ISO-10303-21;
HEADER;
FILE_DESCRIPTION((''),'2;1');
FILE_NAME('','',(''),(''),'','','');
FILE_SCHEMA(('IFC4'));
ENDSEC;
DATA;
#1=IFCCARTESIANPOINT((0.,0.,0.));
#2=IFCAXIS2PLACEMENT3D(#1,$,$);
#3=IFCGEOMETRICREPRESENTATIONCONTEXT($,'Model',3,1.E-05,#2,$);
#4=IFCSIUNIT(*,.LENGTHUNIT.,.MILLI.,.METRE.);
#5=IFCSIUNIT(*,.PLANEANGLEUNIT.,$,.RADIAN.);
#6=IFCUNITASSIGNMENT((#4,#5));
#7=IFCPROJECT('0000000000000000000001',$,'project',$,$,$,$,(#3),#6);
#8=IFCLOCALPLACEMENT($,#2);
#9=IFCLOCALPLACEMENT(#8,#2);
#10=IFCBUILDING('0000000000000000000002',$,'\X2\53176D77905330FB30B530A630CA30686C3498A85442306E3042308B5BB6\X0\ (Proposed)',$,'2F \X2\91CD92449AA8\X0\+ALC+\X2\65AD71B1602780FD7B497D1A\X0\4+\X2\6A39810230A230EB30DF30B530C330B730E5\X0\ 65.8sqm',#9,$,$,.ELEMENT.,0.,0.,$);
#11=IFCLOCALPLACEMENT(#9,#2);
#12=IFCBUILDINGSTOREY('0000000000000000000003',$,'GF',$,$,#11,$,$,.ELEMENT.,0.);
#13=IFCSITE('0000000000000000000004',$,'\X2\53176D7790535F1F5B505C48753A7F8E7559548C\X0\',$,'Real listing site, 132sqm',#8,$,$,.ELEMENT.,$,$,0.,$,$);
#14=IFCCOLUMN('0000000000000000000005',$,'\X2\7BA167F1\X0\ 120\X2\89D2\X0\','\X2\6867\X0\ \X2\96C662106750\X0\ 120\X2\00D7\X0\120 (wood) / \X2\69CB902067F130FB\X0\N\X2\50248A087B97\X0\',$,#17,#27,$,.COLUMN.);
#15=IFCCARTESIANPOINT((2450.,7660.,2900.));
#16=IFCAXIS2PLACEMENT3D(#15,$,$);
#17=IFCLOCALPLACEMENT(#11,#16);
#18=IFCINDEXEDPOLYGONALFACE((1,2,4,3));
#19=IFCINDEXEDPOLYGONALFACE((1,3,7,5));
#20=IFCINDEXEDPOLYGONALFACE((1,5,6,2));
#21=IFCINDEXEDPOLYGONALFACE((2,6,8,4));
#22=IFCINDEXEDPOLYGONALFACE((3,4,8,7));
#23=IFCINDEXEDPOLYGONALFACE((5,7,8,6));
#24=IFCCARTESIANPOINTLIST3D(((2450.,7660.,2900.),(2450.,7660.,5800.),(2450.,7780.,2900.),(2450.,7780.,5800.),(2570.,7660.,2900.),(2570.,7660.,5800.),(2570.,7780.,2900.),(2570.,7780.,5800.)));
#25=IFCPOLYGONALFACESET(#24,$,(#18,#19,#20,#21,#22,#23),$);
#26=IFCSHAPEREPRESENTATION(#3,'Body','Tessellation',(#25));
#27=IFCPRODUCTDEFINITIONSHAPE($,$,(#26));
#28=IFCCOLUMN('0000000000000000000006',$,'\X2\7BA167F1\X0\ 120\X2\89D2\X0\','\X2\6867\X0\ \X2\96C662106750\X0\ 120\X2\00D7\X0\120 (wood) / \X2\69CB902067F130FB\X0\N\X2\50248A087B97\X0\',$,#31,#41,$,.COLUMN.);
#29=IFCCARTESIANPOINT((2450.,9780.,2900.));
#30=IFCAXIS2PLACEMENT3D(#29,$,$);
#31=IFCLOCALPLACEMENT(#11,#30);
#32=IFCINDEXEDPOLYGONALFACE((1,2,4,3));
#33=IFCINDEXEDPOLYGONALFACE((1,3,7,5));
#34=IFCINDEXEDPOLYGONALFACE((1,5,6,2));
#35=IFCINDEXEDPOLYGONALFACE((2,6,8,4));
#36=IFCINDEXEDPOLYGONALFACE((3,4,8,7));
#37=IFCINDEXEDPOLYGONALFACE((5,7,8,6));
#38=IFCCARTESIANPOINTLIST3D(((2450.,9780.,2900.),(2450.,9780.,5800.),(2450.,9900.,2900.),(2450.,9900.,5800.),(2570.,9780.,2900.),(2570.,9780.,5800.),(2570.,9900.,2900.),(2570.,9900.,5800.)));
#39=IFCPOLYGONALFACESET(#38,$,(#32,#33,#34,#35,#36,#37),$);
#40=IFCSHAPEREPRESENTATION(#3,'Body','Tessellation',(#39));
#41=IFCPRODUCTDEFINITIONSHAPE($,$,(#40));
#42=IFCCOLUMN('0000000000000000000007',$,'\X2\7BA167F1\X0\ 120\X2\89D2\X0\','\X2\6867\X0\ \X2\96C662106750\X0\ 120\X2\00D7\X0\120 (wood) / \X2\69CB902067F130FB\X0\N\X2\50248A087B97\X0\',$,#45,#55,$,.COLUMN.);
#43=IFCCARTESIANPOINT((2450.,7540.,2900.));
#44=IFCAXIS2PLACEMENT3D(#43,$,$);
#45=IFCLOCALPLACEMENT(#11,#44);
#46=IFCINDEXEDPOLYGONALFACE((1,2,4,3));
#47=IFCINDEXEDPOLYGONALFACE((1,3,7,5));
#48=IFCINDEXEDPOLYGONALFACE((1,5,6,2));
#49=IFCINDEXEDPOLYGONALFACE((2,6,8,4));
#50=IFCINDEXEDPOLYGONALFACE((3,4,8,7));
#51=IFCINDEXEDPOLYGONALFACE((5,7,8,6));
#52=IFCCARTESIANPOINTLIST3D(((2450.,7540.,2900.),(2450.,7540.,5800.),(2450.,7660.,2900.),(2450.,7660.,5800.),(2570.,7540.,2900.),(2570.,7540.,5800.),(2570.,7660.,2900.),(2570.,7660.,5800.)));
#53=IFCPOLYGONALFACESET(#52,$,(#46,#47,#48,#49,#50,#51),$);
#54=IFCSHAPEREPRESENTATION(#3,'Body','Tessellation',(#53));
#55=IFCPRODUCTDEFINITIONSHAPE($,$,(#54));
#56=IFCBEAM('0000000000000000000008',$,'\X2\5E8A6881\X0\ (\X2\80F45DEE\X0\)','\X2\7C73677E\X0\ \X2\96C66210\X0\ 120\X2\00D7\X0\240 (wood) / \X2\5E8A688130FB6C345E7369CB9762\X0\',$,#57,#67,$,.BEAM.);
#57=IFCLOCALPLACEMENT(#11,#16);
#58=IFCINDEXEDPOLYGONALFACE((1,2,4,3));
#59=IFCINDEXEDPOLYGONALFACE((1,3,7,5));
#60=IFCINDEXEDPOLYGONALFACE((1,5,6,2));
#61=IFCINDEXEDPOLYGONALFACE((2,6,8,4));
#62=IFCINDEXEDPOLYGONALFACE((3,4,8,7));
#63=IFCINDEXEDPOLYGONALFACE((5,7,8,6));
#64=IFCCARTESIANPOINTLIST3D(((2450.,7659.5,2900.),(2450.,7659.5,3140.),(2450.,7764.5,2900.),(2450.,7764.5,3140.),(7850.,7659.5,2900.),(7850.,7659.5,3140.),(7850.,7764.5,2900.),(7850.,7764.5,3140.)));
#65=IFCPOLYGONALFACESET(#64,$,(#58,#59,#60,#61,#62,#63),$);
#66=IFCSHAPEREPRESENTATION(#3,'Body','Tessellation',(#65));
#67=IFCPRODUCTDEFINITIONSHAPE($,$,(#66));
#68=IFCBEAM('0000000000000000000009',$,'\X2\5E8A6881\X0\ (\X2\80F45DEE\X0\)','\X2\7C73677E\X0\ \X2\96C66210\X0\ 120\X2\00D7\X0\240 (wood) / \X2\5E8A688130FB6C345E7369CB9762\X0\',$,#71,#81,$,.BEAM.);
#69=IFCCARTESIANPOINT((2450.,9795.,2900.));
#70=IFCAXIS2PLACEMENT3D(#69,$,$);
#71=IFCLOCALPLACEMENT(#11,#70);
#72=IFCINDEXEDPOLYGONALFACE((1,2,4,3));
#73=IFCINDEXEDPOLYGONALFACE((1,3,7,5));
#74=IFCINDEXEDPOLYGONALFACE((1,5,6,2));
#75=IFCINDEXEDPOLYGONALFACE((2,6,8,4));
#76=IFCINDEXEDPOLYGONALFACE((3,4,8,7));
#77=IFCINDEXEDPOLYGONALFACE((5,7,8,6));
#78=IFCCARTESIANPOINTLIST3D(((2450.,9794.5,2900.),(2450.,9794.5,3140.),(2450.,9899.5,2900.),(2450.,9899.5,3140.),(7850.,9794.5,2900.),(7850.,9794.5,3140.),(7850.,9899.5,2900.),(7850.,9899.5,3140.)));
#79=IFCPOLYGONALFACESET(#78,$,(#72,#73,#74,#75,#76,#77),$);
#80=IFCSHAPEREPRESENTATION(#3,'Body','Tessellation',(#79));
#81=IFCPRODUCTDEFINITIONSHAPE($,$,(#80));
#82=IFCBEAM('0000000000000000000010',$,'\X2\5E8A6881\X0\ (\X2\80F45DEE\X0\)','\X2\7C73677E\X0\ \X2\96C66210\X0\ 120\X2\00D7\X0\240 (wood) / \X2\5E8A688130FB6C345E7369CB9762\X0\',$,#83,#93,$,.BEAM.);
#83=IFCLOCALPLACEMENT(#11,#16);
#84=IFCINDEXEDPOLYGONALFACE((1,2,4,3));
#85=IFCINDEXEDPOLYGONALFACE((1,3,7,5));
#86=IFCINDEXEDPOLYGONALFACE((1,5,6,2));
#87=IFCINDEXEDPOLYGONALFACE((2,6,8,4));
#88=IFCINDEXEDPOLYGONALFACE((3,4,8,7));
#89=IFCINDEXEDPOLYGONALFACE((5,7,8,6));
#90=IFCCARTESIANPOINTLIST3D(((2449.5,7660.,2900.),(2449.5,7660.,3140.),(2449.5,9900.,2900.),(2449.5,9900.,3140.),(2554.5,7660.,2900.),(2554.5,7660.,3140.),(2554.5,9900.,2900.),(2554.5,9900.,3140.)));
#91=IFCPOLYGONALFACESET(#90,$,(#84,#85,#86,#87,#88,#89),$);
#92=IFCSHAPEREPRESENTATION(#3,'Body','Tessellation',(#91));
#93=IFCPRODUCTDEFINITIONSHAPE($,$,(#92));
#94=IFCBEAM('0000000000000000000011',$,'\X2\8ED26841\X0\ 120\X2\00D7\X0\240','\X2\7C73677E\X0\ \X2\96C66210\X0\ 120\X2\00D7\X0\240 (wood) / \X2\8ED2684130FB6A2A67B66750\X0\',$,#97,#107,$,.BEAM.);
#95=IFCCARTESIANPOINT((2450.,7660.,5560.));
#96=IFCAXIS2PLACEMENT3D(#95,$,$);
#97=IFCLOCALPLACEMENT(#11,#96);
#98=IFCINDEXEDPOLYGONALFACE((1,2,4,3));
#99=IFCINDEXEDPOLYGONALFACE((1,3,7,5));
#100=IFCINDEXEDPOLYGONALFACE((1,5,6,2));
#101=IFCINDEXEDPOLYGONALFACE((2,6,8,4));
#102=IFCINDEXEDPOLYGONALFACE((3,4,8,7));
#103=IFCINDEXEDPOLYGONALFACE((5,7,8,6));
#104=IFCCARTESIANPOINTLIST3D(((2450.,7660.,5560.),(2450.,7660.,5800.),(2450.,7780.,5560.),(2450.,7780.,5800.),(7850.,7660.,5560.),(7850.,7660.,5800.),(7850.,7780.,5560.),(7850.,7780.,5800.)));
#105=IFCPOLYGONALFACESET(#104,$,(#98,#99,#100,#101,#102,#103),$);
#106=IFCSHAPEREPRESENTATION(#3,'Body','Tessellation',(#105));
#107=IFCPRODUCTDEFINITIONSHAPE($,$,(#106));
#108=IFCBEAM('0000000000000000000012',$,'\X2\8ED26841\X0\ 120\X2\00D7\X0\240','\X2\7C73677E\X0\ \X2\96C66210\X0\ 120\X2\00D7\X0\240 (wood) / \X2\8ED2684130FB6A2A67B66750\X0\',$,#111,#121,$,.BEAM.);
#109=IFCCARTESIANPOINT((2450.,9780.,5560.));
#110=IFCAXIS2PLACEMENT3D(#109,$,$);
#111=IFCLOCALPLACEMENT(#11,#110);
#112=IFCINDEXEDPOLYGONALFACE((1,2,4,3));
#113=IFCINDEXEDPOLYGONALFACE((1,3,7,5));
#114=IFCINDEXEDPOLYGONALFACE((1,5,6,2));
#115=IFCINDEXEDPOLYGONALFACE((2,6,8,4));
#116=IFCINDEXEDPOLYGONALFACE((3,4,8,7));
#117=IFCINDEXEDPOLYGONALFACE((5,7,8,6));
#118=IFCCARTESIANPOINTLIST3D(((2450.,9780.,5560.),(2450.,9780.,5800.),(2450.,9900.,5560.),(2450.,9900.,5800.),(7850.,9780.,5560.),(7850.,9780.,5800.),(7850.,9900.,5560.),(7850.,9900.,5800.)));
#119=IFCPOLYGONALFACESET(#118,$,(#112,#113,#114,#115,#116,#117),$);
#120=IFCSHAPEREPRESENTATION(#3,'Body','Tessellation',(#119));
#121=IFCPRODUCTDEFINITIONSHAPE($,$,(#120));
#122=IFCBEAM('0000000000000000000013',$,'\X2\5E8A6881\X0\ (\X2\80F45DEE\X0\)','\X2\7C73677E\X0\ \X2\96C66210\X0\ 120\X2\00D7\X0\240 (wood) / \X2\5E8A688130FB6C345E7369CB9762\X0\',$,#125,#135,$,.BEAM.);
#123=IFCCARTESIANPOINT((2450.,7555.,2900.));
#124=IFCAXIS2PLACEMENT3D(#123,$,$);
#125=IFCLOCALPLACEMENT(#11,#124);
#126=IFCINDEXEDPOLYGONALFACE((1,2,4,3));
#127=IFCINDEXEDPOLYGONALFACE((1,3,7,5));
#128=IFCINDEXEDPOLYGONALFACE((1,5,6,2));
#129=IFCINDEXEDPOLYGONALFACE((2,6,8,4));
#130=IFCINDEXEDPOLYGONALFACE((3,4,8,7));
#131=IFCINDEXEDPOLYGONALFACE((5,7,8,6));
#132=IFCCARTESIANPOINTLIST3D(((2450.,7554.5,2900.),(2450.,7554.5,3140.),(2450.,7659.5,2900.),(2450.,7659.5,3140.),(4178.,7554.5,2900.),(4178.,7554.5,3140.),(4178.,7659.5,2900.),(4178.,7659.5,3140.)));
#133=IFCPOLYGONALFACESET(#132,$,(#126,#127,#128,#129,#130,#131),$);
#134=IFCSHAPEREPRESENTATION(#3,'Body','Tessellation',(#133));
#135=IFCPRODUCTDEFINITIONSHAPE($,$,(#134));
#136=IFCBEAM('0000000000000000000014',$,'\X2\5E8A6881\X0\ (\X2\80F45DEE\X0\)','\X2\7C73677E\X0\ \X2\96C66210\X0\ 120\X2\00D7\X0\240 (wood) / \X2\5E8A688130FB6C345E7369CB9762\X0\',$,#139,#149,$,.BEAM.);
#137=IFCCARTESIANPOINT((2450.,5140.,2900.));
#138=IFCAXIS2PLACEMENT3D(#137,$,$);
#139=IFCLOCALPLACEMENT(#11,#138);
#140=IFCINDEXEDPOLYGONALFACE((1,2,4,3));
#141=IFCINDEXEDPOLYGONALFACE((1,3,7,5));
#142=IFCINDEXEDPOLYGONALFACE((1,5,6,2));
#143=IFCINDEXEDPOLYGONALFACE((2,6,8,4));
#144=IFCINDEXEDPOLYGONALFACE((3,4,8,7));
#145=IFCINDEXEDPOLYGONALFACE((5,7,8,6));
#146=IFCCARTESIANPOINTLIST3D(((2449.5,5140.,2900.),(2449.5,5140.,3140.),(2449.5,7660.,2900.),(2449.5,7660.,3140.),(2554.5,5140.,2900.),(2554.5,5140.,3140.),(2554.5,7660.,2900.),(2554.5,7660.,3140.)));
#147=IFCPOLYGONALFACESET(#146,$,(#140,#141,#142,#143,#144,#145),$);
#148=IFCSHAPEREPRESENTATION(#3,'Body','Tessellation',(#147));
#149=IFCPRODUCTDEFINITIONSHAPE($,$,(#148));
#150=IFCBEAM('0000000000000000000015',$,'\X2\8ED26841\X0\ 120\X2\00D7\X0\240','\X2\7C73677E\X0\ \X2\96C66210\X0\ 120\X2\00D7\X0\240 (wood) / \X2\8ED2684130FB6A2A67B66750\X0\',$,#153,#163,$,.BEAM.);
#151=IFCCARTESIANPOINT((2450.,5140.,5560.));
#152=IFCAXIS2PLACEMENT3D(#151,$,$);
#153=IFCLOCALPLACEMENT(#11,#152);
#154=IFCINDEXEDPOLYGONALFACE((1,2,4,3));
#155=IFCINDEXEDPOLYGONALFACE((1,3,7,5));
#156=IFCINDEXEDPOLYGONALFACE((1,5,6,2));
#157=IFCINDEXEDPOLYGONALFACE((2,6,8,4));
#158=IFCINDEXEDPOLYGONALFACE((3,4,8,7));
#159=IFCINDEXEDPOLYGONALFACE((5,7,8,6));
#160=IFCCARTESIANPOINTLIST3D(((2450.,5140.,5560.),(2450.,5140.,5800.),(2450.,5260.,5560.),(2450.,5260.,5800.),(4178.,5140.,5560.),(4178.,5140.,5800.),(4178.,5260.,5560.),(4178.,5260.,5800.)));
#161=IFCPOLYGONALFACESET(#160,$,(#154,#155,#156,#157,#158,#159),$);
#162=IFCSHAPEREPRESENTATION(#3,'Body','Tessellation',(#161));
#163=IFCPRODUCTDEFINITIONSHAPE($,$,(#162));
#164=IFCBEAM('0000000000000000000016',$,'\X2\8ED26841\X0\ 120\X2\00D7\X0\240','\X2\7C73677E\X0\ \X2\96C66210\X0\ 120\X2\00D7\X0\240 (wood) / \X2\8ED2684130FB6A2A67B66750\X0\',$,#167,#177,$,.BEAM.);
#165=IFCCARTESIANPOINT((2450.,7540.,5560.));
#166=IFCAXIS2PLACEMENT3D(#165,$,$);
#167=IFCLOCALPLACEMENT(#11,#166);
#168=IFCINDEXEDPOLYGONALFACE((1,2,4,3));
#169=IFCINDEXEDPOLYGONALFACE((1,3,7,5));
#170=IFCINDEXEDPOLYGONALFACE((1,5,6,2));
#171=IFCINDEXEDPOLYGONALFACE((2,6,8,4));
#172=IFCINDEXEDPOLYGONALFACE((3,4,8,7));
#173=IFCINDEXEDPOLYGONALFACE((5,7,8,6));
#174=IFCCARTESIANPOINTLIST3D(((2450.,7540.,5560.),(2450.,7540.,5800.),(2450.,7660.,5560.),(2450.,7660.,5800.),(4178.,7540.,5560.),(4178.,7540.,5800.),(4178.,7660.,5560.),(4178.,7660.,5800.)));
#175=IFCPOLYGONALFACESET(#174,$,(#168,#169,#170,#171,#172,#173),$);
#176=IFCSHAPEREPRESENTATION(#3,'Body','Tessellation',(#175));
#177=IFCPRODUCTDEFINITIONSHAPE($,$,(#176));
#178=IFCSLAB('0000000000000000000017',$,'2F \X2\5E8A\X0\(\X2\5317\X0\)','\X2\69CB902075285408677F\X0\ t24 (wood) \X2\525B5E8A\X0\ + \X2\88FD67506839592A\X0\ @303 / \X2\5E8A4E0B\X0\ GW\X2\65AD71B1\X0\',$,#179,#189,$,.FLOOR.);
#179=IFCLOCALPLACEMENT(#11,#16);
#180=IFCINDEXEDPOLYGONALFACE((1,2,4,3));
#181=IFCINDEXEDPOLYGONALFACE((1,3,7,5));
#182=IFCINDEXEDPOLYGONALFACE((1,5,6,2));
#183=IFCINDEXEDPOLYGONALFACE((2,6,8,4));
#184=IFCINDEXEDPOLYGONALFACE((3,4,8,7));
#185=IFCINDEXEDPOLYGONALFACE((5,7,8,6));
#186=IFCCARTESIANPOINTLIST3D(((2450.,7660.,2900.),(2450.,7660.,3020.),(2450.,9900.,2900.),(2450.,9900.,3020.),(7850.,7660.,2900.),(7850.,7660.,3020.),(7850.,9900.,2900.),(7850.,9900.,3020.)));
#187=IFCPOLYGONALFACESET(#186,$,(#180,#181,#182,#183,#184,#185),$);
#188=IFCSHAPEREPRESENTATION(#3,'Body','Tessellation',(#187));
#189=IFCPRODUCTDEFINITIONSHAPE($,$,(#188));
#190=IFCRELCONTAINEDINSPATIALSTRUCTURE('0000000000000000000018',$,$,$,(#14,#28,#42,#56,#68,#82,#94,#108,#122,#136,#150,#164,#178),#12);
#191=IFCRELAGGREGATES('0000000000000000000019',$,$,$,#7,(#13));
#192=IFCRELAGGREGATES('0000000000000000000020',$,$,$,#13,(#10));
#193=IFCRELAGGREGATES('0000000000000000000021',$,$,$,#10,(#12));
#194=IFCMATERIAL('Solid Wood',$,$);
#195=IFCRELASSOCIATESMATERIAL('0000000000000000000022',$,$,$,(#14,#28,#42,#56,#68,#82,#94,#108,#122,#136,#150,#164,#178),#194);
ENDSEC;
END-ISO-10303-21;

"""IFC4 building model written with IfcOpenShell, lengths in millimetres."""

from ifc_helpers import new_model, si_unit, frame, frame_2d, origin, place, context, project, spatial, rectangle, extrude, material, element, save


model = new_model("IFC4")

# Units and contexts
model_context = context("Model", 3, precision=1e-05, world=origin())
ifc_project = project(units=[si_unit("LENGTHUNIT", "METRE", prefix="MILLI"), si_unit("PLANEANGLEUNIT", "RADIAN")], contexts=[model_context])

# Site, building, storey
site_placement = place(None, origin())
site = spatial("IfcSite", under=ifc_project, at=site_placement, Name="北海道弟子屈町美留和", ObjectType="Real listing site, 132sqm", CompositionType="ELEMENT", RefElevation=0.0)
building_placement = place(site_placement, origin())
building = spatial("IfcBuilding", under=site, at=building_placement, Name="北海道・サウナと水風呂のある家 (Proposed)", ObjectType="2F 重鉄骨+ALC+断熱性能等級4+樹脂アルミサッシュ 65.8sqm", CompositionType="ELEMENT", ElevationOfRefHeight=0.0, ElevationOfTerrain=0.0)
storey_placement = place(building_placement, origin())
storey = spatial("IfcBuildingStorey", under=building, at=storey_placement, Name="GF", CompositionType="ELEMENT", Elevation=0.0)

# Columns
ifc_material_1 = material(Name="Solid Wood")
column_1_placement = place(storey_placement, frame((2450.0, 7660.0, 2900.0)))
element("IfcColumn", 1, at=column_1_placement, inside=storey, material=ifc_material_1, Name="管柱 120角", Description="桧 集成材 120×120 (wood) / 構造柱・N値計算", PredefinedType="COLUMN", context=model_context, shape_type="SweptSolid", body=[
    extrude(rectangle(XDim=120.0, YDim=120.0, at=frame_2d((60.0, 60.0))), frame((2450.0, 7660.0, 2900.0)), (0.0, 0.0, 1.0), 2900.0),
])
column_2_placement = place(storey_placement, frame((2450.0, 9780.0, 2900.0)))
element("IfcColumn", 2, at=column_2_placement, inside=storey, material=ifc_material_1, Name="管柱 120角", Description="桧 集成材 120×120 (wood) / 構造柱・N値計算", PredefinedType="COLUMN", context=model_context, shape_type="SweptSolid", body=[
    extrude(rectangle(XDim=120.0, YDim=120.0, at=frame_2d((60.0, 60.0))), frame((2450.0, 9780.0, 2900.0)), (0.0, 0.0, 1.0), 2900.0),
])
column_3_placement = place(storey_placement, frame((2450.0, 7540.0, 2900.0)))
element("IfcColumn", 3, at=column_3_placement, inside=storey, material=ifc_material_1, Name="管柱 120角", Description="桧 集成材 120×120 (wood) / 構造柱・N値計算", PredefinedType="COLUMN", context=model_context, shape_type="SweptSolid", body=[
    extrude(rectangle(XDim=120.0, YDim=120.0, at=frame_2d((60.0, 60.0))), frame((2450.0, 7540.0, 2900.0)), (0.0, 0.0, 1.0), 2900.0),
])

# Beams
beam_1_placement = place(storey_placement, frame((2450.0, 7660.0, 2900.0)))
element("IfcBeam", 4, at=beam_1_placement, inside=storey, material=ifc_material_1, Name="床梁 (胴差)", Description="米松 集成 120×240 (wood) / 床梁・水平構面", PredefinedType="BEAM", context=model_context, shape_type="SweptSolid", body=[
    extrude(rectangle(XDim=5400.0, YDim=105.0, at=frame_2d((2700.0, 52.0))), frame((2450.0, 7660.0, 2900.0)), (0.0, 0.0, 1.0), 240.0),
])
beam_2_placement = place(storey_placement, frame((2450.0, 9795.0, 2900.0)))
element("IfcBeam", 5, at=beam_2_placement, inside=storey, material=ifc_material_1, Name="床梁 (胴差)", Description="米松 集成 120×240 (wood) / 床梁・水平構面", PredefinedType="BEAM", context=model_context, shape_type="SweptSolid", body=[
    extrude(rectangle(XDim=5400.0, YDim=105.0, at=frame_2d((2700.0, 52.0))), frame((2450.0, 9795.0, 2900.0)), (0.0, 0.0, 1.0), 240.0),
])
beam_3_placement = place(storey_placement, frame((2450.0, 7660.0, 2900.0)))
element("IfcBeam", 6, at=beam_3_placement, inside=storey, material=ifc_material_1, Name="床梁 (胴差)", Description="米松 集成 120×240 (wood) / 床梁・水平構面", PredefinedType="BEAM", context=model_context, shape_type="SweptSolid", body=[
    extrude(rectangle(XDim=105.0, YDim=2240.0, at=frame_2d((52.0, 1120.0))), frame((2450.0, 7660.0, 2900.0)), (0.0, 0.0, 1.0), 240.0),
])
beam_4_placement = place(storey_placement, frame((2450.0, 7660.0, 5560.0)))
element("IfcBeam", 7, at=beam_4_placement, inside=storey, material=ifc_material_1, Name="軒桁 120×240", Description="米松 集成 120×240 (wood) / 軒桁・横架材", PredefinedType="BEAM", context=model_context, shape_type="SweptSolid", body=[
    extrude(rectangle(XDim=5400.0, YDim=120.0, at=frame_2d((2700.0, 60.0))), frame((2450.0, 7660.0, 5560.0)), (0.0, 0.0, 1.0), 240.0),
])
beam_5_placement = place(storey_placement, frame((2450.0, 9780.0, 5560.0)))
element("IfcBeam", 8, at=beam_5_placement, inside=storey, material=ifc_material_1, Name="軒桁 120×240", Description="米松 集成 120×240 (wood) / 軒桁・横架材", PredefinedType="BEAM", context=model_context, shape_type="SweptSolid", body=[
    extrude(rectangle(XDim=5400.0, YDim=120.0, at=frame_2d((2700.0, 60.0))), frame((2450.0, 9780.0, 5560.0)), (0.0, 0.0, 1.0), 240.0),
])
beam_6_placement = place(storey_placement, frame((2450.0, 7555.0, 2900.0)))
element("IfcBeam", 9, at=beam_6_placement, inside=storey, material=ifc_material_1, Name="床梁 (胴差)", Description="米松 集成 120×240 (wood) / 床梁・水平構面", PredefinedType="BEAM", context=model_context, shape_type="SweptSolid", body=[
    extrude(rectangle(XDim=1728.0, YDim=105.0, at=frame_2d((864.0, 52.0))), frame((2450.0, 7555.0, 2900.0)), (0.0, 0.0, 1.0), 240.0),
])
beam_7_placement = place(storey_placement, frame((2450.0, 5140.0, 2900.0)))
element("IfcBeam", 10, at=beam_7_placement, inside=storey, material=ifc_material_1, Name="床梁 (胴差)", Description="米松 集成 120×240 (wood) / 床梁・水平構面", PredefinedType="BEAM", context=model_context, shape_type="SweptSolid", body=[
    extrude(rectangle(XDim=105.0, YDim=2520.0, at=frame_2d((52.0, 1260.0))), frame((2450.0, 5140.0, 2900.0)), (0.0, 0.0, 1.0), 240.0),
])
beam_8_placement = place(storey_placement, frame((2450.0, 5140.0, 5560.0)))
element("IfcBeam", 11, at=beam_8_placement, inside=storey, material=ifc_material_1, Name="軒桁 120×240", Description="米松 集成 120×240 (wood) / 軒桁・横架材", PredefinedType="BEAM", context=model_context, shape_type="SweptSolid", body=[
    extrude(rectangle(XDim=1728.0, YDim=120.0, at=frame_2d((864.0, 60.0))), frame((2450.0, 5140.0, 5560.0)), (0.0, 0.0, 1.0), 240.0),
])
beam_9_placement = place(storey_placement, frame((2450.0, 7540.0, 5560.0)))
element("IfcBeam", 12, at=beam_9_placement, inside=storey, material=ifc_material_1, Name="軒桁 120×240", Description="米松 集成 120×240 (wood) / 軒桁・横架材", PredefinedType="BEAM", context=model_context, shape_type="SweptSolid", body=[
    extrude(rectangle(XDim=1728.0, YDim=120.0, at=frame_2d((864.0, 60.0))), frame((2450.0, 7540.0, 5560.0)), (0.0, 0.0, 1.0), 240.0),
])

# Slab
slab_placement = place(storey_placement, frame((2450.0, 7660.0, 2900.0)))
element("IfcSlab", 13, at=slab_placement, inside=storey, material=ifc_material_1, Name="2F 床(北)", Description="構造用合板 t24 (wood) 剛床 + 製材根太 @303 / 床下 GW断熱", PredefinedType="FLOOR", context=model_context, shape_type="SweptSolid", body=[
    extrude(rectangle(XDim=5400.0, YDim=2240.0, at=frame_2d((2700.0, 1120.0))), frame((2450.0, 7660.0, 2900.0)), (0.0, 0.0, 1.0), 120.0),
])

save(model, "model.ifc")
